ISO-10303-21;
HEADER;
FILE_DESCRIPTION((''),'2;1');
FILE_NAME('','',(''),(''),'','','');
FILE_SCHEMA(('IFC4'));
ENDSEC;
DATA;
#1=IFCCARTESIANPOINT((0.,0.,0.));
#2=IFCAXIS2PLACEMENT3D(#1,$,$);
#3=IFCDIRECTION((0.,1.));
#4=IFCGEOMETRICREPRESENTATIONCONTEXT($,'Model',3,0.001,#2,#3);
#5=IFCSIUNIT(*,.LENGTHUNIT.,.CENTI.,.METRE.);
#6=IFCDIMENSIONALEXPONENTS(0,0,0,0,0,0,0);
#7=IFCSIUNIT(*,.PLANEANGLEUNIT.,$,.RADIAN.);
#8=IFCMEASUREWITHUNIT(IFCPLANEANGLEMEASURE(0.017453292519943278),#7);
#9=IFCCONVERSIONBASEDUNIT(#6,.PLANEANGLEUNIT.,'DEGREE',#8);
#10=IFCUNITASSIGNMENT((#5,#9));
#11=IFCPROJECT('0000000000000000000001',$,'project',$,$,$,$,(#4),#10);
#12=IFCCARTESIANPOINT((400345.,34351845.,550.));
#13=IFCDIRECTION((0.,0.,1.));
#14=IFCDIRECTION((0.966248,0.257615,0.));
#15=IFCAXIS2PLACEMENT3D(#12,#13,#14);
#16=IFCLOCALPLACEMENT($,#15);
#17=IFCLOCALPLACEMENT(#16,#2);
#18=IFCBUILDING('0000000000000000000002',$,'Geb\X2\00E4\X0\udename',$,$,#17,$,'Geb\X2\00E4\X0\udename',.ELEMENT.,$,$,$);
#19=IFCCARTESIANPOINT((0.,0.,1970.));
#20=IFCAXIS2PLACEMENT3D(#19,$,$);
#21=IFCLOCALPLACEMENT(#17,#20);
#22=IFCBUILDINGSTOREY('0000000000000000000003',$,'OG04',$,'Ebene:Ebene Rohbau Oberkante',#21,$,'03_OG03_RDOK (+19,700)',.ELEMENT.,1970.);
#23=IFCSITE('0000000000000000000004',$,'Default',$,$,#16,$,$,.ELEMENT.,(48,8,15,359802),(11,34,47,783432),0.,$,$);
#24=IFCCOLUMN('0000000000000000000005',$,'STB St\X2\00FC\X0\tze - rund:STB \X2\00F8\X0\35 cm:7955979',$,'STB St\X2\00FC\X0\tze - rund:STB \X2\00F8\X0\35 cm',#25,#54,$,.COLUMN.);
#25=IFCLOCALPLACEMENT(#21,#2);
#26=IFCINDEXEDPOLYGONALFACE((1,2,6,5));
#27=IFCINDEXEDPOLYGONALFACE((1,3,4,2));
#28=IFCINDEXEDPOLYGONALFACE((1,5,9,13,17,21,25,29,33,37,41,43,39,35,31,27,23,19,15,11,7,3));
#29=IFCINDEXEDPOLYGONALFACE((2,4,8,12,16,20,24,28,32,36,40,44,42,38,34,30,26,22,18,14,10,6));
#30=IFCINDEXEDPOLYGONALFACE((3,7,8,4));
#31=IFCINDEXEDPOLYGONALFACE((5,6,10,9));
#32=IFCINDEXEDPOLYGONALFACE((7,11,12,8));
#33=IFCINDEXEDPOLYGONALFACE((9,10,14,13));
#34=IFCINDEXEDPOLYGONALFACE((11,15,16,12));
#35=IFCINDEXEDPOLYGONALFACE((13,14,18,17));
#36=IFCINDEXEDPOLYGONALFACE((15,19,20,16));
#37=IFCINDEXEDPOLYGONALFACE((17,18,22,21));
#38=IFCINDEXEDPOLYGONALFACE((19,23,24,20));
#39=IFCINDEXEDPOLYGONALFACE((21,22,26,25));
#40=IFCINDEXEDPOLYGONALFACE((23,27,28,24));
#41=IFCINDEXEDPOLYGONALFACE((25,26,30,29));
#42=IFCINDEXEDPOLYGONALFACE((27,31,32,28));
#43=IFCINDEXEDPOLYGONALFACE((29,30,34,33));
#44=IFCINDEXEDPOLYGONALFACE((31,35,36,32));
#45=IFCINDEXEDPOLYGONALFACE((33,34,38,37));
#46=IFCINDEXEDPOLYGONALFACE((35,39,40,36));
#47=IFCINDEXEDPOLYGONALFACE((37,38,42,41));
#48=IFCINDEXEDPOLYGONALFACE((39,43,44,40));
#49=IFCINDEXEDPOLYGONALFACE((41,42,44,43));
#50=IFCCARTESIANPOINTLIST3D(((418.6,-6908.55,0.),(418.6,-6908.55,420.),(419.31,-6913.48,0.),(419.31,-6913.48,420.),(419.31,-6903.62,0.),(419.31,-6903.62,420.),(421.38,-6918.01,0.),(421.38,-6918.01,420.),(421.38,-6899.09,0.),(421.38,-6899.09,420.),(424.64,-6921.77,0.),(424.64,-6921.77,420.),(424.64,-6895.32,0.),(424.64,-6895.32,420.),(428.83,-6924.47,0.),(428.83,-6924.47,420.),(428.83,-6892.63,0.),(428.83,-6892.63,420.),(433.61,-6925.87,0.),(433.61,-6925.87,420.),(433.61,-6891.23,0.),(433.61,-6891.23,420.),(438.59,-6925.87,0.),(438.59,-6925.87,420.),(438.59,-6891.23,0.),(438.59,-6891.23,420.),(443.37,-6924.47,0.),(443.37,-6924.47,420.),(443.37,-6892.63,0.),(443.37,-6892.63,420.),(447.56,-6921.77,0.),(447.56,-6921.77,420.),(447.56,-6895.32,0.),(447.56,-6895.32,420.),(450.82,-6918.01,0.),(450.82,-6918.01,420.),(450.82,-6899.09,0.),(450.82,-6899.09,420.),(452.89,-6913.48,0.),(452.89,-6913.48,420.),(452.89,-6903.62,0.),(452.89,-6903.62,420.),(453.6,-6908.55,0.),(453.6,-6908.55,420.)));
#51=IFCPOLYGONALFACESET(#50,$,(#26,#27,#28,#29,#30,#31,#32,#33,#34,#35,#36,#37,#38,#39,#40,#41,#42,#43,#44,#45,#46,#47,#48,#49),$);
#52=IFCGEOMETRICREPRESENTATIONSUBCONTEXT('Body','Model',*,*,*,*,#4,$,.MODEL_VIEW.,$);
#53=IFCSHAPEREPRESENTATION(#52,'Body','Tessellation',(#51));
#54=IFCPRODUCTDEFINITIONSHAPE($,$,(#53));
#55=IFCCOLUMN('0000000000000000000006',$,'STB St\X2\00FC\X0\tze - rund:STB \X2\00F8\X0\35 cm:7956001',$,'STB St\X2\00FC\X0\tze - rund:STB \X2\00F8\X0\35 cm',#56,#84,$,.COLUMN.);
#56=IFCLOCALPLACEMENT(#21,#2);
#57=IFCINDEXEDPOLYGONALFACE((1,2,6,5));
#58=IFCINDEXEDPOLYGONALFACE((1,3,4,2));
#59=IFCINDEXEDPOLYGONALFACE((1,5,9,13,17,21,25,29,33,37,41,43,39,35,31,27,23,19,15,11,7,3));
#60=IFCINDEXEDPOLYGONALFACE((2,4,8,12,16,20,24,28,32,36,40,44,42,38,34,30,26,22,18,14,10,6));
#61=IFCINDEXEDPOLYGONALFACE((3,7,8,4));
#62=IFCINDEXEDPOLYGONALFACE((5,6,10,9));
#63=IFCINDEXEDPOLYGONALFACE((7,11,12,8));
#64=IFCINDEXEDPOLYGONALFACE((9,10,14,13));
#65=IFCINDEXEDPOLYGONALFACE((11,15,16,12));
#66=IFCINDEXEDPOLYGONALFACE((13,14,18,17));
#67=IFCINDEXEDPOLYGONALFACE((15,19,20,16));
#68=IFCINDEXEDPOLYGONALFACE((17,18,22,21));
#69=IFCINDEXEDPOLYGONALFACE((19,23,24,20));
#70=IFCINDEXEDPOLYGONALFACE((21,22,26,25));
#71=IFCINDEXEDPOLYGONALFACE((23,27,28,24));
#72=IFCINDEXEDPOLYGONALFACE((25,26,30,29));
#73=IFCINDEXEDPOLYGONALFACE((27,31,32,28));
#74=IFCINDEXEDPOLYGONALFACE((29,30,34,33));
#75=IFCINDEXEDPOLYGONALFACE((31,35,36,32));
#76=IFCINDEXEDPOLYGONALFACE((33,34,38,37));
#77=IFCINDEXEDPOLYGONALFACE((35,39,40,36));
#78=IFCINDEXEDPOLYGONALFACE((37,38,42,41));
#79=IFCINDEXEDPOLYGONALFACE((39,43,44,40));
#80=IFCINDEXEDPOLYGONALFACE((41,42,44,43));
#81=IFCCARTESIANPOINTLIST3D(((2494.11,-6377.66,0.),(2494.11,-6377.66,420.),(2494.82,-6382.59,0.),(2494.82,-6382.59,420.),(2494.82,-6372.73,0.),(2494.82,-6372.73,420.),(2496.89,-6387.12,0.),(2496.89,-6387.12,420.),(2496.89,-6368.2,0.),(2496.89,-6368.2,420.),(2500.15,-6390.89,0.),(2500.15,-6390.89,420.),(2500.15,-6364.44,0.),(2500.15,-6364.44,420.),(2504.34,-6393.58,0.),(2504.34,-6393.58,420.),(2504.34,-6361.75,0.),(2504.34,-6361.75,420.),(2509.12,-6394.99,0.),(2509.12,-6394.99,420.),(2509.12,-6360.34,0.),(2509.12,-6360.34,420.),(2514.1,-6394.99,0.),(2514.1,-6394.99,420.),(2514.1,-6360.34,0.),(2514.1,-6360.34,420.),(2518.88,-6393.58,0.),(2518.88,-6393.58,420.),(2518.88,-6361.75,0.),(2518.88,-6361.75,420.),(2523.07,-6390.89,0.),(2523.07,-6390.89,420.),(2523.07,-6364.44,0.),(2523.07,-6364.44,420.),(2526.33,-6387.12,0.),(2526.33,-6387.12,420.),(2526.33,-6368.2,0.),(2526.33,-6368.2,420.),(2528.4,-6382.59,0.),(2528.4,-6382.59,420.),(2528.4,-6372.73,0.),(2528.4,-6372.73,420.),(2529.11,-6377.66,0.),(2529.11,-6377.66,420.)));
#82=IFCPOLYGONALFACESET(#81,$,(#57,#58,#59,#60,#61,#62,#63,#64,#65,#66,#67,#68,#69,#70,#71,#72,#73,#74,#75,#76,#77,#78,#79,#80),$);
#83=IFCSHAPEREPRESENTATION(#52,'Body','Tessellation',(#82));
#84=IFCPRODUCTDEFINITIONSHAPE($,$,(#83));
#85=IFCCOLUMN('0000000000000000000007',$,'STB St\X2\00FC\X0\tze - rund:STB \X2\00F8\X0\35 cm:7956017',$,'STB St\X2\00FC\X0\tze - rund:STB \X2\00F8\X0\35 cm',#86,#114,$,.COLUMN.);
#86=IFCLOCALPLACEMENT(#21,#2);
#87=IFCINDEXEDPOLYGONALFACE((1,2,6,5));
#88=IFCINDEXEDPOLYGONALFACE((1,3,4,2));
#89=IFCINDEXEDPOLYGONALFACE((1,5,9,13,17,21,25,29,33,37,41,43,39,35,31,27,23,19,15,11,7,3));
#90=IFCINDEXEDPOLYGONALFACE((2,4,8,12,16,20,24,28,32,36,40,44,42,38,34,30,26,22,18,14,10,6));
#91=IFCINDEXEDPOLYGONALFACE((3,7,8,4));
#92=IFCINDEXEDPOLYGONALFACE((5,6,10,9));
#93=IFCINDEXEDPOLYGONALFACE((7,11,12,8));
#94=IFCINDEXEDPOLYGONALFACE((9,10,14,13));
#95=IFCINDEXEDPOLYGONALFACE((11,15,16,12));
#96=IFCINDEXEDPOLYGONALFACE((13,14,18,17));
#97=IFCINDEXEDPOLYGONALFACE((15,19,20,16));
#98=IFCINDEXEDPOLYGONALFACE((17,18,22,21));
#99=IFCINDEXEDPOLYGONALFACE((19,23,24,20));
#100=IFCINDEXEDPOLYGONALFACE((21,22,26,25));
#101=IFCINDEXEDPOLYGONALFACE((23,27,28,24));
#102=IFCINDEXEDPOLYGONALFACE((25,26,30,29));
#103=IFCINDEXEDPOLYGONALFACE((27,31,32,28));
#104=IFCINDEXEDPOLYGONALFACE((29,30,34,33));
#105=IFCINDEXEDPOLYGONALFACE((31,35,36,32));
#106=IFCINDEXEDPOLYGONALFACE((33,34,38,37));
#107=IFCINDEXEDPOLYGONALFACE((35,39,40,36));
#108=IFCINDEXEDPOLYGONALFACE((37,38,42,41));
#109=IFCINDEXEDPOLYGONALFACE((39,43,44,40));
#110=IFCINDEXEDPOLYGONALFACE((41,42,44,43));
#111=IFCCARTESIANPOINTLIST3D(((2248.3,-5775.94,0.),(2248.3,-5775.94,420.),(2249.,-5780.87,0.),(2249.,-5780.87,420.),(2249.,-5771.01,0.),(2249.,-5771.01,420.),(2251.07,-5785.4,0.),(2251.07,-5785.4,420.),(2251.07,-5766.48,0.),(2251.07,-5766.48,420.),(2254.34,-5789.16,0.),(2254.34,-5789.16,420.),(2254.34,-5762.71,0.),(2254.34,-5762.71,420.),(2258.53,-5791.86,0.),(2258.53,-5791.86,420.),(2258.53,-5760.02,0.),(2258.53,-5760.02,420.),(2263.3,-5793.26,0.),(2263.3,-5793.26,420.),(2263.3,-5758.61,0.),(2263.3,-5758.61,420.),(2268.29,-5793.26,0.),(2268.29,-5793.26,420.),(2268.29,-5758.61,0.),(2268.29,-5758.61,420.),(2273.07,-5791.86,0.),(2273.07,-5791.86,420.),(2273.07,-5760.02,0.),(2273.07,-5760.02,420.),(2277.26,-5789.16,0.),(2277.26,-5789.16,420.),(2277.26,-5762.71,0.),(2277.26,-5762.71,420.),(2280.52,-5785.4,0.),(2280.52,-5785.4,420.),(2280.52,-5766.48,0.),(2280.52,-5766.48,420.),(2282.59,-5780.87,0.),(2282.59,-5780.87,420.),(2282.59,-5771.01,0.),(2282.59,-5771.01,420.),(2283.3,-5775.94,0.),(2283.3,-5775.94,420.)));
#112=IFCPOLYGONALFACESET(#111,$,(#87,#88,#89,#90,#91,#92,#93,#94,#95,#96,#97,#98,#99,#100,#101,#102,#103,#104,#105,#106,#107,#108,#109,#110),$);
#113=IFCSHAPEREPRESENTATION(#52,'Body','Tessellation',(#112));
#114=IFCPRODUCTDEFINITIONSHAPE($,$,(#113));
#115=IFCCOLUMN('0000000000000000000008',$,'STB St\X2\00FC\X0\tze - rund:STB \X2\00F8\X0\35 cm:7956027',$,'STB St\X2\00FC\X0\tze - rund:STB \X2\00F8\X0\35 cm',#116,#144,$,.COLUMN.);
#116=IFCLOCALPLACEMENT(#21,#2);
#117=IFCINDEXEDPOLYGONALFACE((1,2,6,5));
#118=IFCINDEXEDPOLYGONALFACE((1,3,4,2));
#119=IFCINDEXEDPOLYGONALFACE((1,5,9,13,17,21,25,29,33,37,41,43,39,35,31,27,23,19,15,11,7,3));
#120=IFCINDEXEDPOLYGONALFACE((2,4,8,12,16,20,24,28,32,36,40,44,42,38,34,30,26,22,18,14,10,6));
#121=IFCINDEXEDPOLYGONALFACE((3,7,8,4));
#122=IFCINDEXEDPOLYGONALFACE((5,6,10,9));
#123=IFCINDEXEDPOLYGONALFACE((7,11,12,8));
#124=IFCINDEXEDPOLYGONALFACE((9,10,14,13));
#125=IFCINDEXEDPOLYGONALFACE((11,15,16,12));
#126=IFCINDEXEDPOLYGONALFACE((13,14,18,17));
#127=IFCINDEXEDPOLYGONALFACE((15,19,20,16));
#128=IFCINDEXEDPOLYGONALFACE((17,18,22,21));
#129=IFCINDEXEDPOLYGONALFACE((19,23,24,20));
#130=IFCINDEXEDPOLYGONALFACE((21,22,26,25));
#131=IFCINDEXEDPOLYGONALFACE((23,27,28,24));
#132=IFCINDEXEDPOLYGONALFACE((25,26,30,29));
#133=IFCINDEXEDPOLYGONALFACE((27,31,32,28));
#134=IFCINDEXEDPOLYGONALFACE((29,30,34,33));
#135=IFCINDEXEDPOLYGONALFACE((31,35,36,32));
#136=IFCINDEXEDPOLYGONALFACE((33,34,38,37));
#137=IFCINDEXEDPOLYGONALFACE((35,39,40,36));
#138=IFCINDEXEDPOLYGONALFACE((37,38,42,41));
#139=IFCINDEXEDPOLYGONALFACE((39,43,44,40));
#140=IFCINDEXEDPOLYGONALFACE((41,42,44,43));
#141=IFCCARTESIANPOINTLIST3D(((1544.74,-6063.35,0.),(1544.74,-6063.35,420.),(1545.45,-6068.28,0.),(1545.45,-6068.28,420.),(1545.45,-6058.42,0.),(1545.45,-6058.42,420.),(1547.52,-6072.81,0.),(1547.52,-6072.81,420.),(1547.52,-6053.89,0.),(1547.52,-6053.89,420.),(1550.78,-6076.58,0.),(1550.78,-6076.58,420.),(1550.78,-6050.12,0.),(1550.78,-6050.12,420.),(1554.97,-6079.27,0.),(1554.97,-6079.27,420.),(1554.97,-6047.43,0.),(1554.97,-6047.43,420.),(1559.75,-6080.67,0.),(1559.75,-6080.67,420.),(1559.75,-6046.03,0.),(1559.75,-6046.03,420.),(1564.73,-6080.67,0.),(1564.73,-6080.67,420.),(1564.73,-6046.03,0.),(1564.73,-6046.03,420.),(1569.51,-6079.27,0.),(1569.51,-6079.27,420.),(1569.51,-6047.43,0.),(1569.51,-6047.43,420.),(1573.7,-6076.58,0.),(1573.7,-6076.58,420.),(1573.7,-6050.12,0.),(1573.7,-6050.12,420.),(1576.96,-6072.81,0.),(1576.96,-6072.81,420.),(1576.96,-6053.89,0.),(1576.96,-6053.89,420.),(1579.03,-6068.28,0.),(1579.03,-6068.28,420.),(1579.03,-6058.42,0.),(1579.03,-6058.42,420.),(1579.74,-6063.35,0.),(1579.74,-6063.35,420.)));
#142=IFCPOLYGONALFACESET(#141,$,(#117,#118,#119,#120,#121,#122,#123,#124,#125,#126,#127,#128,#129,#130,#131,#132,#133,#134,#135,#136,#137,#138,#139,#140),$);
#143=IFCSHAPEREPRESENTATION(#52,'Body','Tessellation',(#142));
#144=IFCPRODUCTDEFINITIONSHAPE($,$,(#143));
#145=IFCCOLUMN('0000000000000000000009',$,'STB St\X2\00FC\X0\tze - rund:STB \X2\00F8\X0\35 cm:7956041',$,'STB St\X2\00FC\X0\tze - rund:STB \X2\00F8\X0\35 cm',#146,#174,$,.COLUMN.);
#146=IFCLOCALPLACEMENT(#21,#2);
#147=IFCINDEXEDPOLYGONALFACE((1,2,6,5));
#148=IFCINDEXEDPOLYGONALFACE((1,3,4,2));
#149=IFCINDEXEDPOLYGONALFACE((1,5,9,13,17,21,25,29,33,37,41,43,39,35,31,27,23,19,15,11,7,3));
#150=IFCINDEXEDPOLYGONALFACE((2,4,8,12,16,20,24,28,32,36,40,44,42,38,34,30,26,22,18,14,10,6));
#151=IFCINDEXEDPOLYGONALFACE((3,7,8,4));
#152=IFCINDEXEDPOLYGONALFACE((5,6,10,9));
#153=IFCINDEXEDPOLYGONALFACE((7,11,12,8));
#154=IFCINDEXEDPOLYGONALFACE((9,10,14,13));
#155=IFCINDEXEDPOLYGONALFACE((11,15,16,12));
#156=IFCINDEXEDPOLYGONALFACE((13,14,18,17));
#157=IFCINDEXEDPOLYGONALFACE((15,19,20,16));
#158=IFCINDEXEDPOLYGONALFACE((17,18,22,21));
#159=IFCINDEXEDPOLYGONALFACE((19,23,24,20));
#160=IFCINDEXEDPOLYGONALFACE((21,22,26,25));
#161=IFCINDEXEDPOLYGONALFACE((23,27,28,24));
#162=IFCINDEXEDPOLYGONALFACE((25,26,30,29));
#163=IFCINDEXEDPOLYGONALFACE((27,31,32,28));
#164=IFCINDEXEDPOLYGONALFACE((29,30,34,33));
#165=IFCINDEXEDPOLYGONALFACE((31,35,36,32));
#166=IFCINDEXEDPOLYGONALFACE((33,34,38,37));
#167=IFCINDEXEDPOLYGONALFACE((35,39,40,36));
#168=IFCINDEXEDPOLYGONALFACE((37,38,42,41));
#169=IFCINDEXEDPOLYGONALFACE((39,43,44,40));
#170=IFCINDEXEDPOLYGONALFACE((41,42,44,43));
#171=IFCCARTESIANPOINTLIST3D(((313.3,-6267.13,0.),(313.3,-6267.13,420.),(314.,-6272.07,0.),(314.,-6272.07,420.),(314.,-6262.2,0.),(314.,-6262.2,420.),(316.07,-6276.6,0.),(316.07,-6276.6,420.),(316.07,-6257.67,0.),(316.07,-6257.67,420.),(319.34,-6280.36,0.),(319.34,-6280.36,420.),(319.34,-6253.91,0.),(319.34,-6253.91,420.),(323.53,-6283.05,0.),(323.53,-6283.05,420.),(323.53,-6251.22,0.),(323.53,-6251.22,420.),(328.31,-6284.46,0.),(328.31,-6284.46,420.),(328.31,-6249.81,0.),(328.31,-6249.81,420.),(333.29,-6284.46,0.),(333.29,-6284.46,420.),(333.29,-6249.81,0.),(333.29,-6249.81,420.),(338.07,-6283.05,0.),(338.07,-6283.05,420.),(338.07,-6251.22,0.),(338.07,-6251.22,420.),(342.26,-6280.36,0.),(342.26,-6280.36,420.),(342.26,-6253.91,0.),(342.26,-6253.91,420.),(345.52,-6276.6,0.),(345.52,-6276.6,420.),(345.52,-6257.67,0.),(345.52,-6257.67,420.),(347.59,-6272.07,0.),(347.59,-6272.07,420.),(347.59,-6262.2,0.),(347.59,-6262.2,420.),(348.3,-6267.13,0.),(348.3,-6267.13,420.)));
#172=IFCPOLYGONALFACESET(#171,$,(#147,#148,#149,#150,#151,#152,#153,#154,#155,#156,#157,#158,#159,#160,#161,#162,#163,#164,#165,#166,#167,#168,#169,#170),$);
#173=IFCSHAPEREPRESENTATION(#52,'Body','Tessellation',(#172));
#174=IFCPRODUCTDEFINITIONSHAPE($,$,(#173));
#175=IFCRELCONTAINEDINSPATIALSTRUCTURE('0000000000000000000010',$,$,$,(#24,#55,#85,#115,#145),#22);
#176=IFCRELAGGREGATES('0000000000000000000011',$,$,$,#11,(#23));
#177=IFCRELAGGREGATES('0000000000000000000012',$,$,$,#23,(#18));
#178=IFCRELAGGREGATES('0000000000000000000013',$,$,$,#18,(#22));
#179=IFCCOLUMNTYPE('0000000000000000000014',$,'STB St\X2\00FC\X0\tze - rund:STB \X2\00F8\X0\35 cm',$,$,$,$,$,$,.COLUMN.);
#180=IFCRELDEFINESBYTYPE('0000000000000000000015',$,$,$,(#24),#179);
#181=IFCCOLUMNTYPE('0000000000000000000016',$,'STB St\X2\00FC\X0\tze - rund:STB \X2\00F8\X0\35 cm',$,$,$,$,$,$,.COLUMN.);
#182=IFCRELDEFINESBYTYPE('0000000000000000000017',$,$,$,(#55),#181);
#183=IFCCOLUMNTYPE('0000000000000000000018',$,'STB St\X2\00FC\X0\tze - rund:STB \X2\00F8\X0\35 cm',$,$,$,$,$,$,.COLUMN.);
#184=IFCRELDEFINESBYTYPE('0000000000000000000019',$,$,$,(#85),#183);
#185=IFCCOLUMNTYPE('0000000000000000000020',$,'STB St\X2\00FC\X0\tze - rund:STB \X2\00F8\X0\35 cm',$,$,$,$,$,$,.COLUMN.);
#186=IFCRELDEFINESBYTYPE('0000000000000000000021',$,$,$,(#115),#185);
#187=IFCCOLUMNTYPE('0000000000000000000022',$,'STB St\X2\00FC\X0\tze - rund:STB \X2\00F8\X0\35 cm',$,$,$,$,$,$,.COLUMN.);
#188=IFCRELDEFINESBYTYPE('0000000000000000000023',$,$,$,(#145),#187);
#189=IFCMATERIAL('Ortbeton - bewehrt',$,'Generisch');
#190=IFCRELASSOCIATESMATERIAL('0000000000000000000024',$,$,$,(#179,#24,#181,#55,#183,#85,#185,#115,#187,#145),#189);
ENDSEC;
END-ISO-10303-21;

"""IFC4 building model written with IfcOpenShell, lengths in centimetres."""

from ifc_helpers import new_model, entity, si_unit, converted_unit, direction, frame, origin, place, context, subcontext, project, spatial, arc, indexed_curve, outline, extrude, source, transform, mapped, material, type_object, type_shapes, element, save


model = new_model("IFC4")

# Units and contexts
model_context = context("Model", 3, precision=0.001, world=origin(), true_north=direction((0.0, 1.0)))
body_context = subcontext(model_context, "Body", "Model", "MODEL_VIEW")
ifc_project = project(units=[si_unit("LENGTHUNIT", "METRE", prefix="CENTI"), converted_unit("PLANEANGLEUNIT", "DEGREE", entity("IfcPlaneAngleMeasure", 0.017453292519943278), si_unit("PLANEANGLEUNIT", "RADIAN"), dimensions=[0, 0, 0, 0, 0, 0, 0])], contexts=[model_context])

# Site, building, storey
site_placement = place(None, frame((400345.0, 34351845.0, 550.0), z_axis=(0.0, 0.0, 1.0), x_axis=(0.966248, 0.257615, 0.0)))
site = spatial("IfcSite", under=ifc_project, at=site_placement, Name="Default", CompositionType="ELEMENT", RefLatitude=(48, 8, 15, 359802), RefLongitude=(11, 34, 47, 783432), RefElevation=0.0)
building_placement = place(site_placement, origin())
building = spatial("IfcBuilding", under=site, at=building_placement, Name="Gebäudename", LongName="Gebäudename", CompositionType="ELEMENT")
storey_placement = place(building_placement, frame((0.0, 0.0, 1970.0)))
storey = spatial("IfcBuildingStorey", under=building, at=storey_placement, Name="OG04", ObjectType="Ebene:Ebene Rohbau Oberkante", LongName="03_OG03_RDOK (+19,700)", CompositionType="ELEMENT", Elevation=1970.0)

# Columns
ifc_material = material(Name="Ortbeton - bewehrt", Category="Generisch")
column_type_1 = type_object("IfcColumnType", Name="STB Stütze - rund:STB ø35 cm", PredefinedType="COLUMN", material=ifc_material)
shared_shape_1 = source(origin(), body_context, "Body", "SweptSolid", [
    extrude(outline(indexed_curve([(-17.5, 0.0), (0.0, -17.5), (17.5, 0.0), (0.0, 17.5)], segments=[arc(1, 2, 3), arc(3, 4, 1)], self_intersect=False)), frame((436.1, -6908.55, 1970.0)), (0.0, 0.0, 1.0), 420.0),
])
type_shapes(column_type_1, [shared_shape_1])
column_1_placement = place(storey_placement, frame((0.0, 0.0, -1970.0)))
element("IfcColumn", 1, at=column_1_placement, inside=storey, type_object=column_type_1, material=ifc_material, Name="STB Stütze - rund:STB ø35 cm:7955979", ObjectType="STB Stütze - rund:STB ø35 cm", PredefinedType="COLUMN", context=body_context, shape_type="MappedRepresentation", body=[
    mapped(shared_shape_1, transform((0.0, 0.0, 0.0), scale=1.0)),
])
column_type_2 = type_object("IfcColumnType", Name="STB Stütze - rund:STB ø35 cm", PredefinedType="COLUMN", material=ifc_material)
shared_shape_2 = source(origin(), body_context, "Body", "SweptSolid", [
    extrude(outline(indexed_curve([(-17.5, 0.0), (0.0, -17.5), (17.5, 0.0), (0.0, 17.5)], segments=[arc(1, 2, 3), arc(3, 4, 1)], self_intersect=False)), frame((2511.61, -6377.66, 1970.0)), (0.0, 0.0, 1.0), 420.0),
])
type_shapes(column_type_2, [shared_shape_2])
column_2_placement = place(storey_placement, frame((0.0, 0.0, -1970.0)))
element("IfcColumn", 2, at=column_2_placement, inside=storey, type_object=column_type_2, material=ifc_material, Name="STB Stütze - rund:STB ø35 cm:7956001", ObjectType="STB Stütze - rund:STB ø35 cm", PredefinedType="COLUMN", context=body_context, shape_type="MappedRepresentation", body=[
    mapped(shared_shape_2, transform((0.0, 0.0, 0.0), scale=1.0)),
])
column_type_3 = type_object("IfcColumnType", Name="STB Stütze - rund:STB ø35 cm", PredefinedType="COLUMN", material=ifc_material)
shared_shape_3 = source(origin(), body_context, "Body", "SweptSolid", [
    extrude(outline(indexed_curve([(-17.5, 0.0), (0.0, -17.5), (17.5, 0.0), (0.0, 17.5)], segments=[arc(1, 2, 3), arc(3, 4, 1)], self_intersect=False)), frame((2265.8, -5775.94, 1970.0)), (0.0, 0.0, 1.0), 420.0),
])
type_shapes(column_type_3, [shared_shape_3])
column_3_placement = place(storey_placement, frame((0.0, 0.0, -1970.0)))
element("IfcColumn", 3, at=column_3_placement, inside=storey, type_object=column_type_3, material=ifc_material, Name="STB Stütze - rund:STB ø35 cm:7956017", ObjectType="STB Stütze - rund:STB ø35 cm", PredefinedType="COLUMN", context=body_context, shape_type="MappedRepresentation", body=[
    mapped(shared_shape_3, transform((0.0, 0.0, 0.0), scale=1.0)),
])
column_type_4 = type_object("IfcColumnType", Name="STB Stütze - rund:STB ø35 cm", PredefinedType="COLUMN", material=ifc_material)
shared_shape_4 = source(origin(), body_context, "Body", "SweptSolid", [
    extrude(outline(indexed_curve([(-17.5, 0.0), (0.0, -17.5), (17.5, 0.0), (0.0, 17.5)], segments=[arc(1, 2, 3), arc(3, 4, 1)], self_intersect=False)), frame((1562.24, -6063.35, 1970.0)), (0.0, 0.0, 1.0), 420.0),
])
type_shapes(column_type_4, [shared_shape_4])
column_4_placement = place(storey_placement, frame((0.0, 0.0, -1970.0)))
element("IfcColumn", 4, at=column_4_placement, inside=storey, type_object=column_type_4, material=ifc_material, Name="STB Stütze - rund:STB ø35 cm:7956027", ObjectType="STB Stütze - rund:STB ø35 cm", PredefinedType="COLUMN", context=body_context, shape_type="MappedRepresentation", body=[
    mapped(shared_shape_4, transform((0.0, 0.0, 0.0), scale=1.0)),
])
column_type_5 = type_object("IfcColumnType", Name="STB Stütze - rund:STB ø35 cm", PredefinedType="COLUMN", material=ifc_material)
shared_shape_5 = source(origin(), body_context, "Body", "SweptSolid", [
    extrude(outline(indexed_curve([(-17.5, 0.0), (0.0, -17.5), (17.5, 0.0), (0.0, 17.5)], segments=[arc(1, 2, 3), arc(3, 4, 1)], self_intersect=False)), frame((330.8, -6267.13, 1970.0)), (0.0, 0.0, 1.0), 420.0),
])
type_shapes(column_type_5, [shared_shape_5])
column_5_placement = place(storey_placement, frame((0.0, 0.0, -1970.0)))
element("IfcColumn", 5, at=column_5_placement, inside=storey, type_object=column_type_5, material=ifc_material, Name="STB Stütze - rund:STB ø35 cm:7956041", ObjectType="STB Stütze - rund:STB ø35 cm", PredefinedType="COLUMN", context=body_context, shape_type="MappedRepresentation", body=[
    mapped(shared_shape_5, transform((0.0, 0.0, 0.0), scale=1.0)),
])

save(model, "model.ifc")
